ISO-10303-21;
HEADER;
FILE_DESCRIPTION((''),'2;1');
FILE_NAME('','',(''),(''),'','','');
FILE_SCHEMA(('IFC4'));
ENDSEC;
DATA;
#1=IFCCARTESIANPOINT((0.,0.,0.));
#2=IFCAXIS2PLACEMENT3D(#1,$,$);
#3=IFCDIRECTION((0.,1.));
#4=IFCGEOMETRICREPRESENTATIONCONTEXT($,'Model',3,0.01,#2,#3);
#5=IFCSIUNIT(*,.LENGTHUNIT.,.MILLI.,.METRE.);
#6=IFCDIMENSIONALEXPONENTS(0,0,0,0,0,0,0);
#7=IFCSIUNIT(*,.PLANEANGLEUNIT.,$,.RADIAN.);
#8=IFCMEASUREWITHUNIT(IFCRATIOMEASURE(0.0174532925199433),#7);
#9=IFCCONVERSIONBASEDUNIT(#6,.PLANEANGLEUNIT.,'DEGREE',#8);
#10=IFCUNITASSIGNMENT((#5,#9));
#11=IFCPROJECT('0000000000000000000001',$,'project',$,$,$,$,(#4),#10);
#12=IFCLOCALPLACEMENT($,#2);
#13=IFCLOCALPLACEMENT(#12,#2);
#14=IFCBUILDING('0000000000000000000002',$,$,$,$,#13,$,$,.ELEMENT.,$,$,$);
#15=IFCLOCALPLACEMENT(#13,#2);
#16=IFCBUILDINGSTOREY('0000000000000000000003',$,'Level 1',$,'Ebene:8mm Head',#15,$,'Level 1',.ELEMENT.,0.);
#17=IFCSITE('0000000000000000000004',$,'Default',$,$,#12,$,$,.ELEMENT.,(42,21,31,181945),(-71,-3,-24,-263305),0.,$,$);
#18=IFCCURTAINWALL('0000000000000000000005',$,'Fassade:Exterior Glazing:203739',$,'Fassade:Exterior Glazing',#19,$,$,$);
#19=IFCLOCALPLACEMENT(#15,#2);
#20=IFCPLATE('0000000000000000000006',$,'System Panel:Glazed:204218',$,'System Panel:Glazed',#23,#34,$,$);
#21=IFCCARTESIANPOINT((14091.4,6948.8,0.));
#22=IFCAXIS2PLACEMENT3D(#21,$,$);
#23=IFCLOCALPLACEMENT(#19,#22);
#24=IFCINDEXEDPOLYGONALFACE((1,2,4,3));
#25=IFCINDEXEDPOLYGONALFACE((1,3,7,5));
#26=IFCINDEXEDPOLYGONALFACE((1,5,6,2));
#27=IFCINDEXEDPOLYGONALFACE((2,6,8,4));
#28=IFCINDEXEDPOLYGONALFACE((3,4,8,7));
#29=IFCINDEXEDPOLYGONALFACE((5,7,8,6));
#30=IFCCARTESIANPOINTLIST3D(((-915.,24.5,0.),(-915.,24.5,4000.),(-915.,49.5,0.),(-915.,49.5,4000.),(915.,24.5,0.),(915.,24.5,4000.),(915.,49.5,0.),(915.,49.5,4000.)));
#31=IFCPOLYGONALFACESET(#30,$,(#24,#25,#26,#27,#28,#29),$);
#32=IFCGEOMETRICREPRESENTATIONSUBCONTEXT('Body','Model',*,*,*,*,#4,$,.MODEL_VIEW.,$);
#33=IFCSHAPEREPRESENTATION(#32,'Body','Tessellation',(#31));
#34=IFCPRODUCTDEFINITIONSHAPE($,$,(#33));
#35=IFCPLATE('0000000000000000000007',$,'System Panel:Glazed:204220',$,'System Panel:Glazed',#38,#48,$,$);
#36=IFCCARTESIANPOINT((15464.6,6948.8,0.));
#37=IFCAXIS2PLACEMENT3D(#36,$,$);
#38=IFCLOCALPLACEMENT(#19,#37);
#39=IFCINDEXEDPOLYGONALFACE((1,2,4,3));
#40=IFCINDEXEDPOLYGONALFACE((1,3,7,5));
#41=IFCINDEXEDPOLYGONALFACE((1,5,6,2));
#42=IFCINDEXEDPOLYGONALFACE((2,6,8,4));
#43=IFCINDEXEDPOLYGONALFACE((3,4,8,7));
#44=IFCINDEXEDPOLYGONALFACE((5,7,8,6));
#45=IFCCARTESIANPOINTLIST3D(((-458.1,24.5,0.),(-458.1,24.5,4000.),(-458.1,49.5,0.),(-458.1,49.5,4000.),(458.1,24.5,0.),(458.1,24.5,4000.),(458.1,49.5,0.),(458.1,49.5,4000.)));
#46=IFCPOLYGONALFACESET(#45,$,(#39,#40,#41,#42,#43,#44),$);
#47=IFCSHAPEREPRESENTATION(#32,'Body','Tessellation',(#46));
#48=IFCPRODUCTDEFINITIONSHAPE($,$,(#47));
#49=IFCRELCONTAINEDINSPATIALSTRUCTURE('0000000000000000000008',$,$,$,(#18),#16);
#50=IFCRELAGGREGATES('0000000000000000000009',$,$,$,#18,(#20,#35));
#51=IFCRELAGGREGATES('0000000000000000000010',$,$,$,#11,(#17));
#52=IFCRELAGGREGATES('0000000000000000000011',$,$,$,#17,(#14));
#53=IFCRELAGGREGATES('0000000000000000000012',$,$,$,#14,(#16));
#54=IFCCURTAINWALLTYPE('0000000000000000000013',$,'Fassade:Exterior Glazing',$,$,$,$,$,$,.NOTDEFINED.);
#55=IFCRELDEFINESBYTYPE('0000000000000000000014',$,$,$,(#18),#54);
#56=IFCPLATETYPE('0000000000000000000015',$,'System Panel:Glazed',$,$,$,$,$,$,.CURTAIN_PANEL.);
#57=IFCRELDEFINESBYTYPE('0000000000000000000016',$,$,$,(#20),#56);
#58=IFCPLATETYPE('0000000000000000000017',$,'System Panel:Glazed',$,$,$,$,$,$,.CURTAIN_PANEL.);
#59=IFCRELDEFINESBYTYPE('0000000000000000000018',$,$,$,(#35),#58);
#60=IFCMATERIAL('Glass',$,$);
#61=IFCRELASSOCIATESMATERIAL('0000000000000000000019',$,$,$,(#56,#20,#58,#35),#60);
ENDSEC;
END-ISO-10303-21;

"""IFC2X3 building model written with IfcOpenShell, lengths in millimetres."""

from ifc_helpers import new_model, entity, si_unit, converted_unit, direction, frame, origin, origin_2d_with_axis, place, context, subcontext, project, spatial, rectangle, extrude, source, transform, mapped, material, type_object, type_shapes, element, aggregate, save


model = new_model("IFC2X3")

# Units and contexts
model_context = context("Model", 3, precision=0.01, world=origin(), true_north=direction((0.0, 1.0)))
body_context = subcontext(model_context, "Body", "Model", "MODEL_VIEW")
ifc_project = project(units=[si_unit("LENGTHUNIT", "METRE", prefix="MILLI"), converted_unit("PLANEANGLEUNIT", "DEGREE", entity("IfcRatioMeasure", 0.0174532925199433), si_unit("PLANEANGLEUNIT", "RADIAN"), dimensions=[0, 0, 0, 0, 0, 0, 0])], contexts=[model_context])

# Site, building, storey
site_placement = place(None, origin())
site = spatial("IfcSite", under=ifc_project, at=site_placement, Name="Default", CompositionType="ELEMENT", RefLatitude=(42, 21, 31, 181945), RefLongitude=(-71, -3, -24, -263305), RefElevation=0.0)
building_placement = place(site_placement, origin())
building = spatial("IfcBuilding", under=site, at=building_placement, CompositionType="ELEMENT")
storey_placement = place(building_placement, origin())
storey = spatial("IfcBuildingStorey", under=building, at=storey_placement, Name="Level 1", ObjectType="Ebene:8mm Head", LongName="Level 1", CompositionType="ELEMENT", Elevation=0.0)

# Curtain wall, plates
curtain_wall_type = type_object("IfcCurtainWallType", Name="Fassade:Exterior Glazing", PredefinedType="NOTDEFINED")
curtain_wall_placement = place(storey_placement, origin())
curtain_wall = element("IfcCurtainWall", 1, at=curtain_wall_placement, inside=storey, type_object=curtain_wall_type, Name="Fassade:Exterior Glazing:203739", ObjectType="Fassade:Exterior Glazing")
ifc_material_1 = material(Name="Glass")
plate_type_1 = type_object("IfcPlateType", Name="System Panel:Glazed", PredefinedType="CURTAIN_PANEL", material=ifc_material_1)
shared_shape_1 = source(origin(), body_context, "Body", "SweptSolid", [
    extrude(rectangle(XDim=25.0, YDim=1830.0, at=origin_2d_with_axis()), frame((0.0, 37.0, 0.0), z_axis=(0.0, 0.0, 1.0), x_axis=(0.0, 1.0, 0.0)), (0.0, 0.0, 1.0), 4000.0),
])
type_shapes(plate_type_1, [shared_shape_1])
plate_1_placement = place(curtain_wall_placement, frame((14091.4, 6948.8, 0.0)))
plate_1 = element("IfcPlate", 2, at=plate_1_placement, type_object=plate_type_1, material=ifc_material_1, Name="System Panel:Glazed:204218", ObjectType="System Panel:Glazed", context=body_context, shape_type="MappedRepresentation", body=[
    mapped(shared_shape_1, transform((0.0, 0.0, 0.0), scale=1.0)),
])
plate_type_2 = type_object("IfcPlateType", Name="System Panel:Glazed", PredefinedType="CURTAIN_PANEL", material=ifc_material_1)
shared_shape_2 = source(origin(), body_context, "Body", "SweptSolid", [
    extrude(rectangle(XDim=25.0, YDim=916.3, at=origin_2d_with_axis()), frame((0.0, 37.0, 0.0), z_axis=(0.0, 0.0, 1.0), x_axis=(0.0, 1.0, 0.0)), (0.0, 0.0, 1.0), 4000.0),
])
type_shapes(plate_type_2, [shared_shape_2])
plate_2_placement = place(curtain_wall_placement, frame((15464.6, 6948.8, 0.0)))
plate_2 = element("IfcPlate", 3, at=plate_2_placement, type_object=plate_type_2, material=ifc_material_1, Name="System Panel:Glazed:204220", ObjectType="System Panel:Glazed", context=body_context, shape_type="MappedRepresentation", body=[
    mapped(shared_shape_2, transform((0.0, 0.0, 0.0), scale=1.0)),
])
aggregate(curtain_wall, [plate_1, plate_2])

save(model, "model.ifc")
